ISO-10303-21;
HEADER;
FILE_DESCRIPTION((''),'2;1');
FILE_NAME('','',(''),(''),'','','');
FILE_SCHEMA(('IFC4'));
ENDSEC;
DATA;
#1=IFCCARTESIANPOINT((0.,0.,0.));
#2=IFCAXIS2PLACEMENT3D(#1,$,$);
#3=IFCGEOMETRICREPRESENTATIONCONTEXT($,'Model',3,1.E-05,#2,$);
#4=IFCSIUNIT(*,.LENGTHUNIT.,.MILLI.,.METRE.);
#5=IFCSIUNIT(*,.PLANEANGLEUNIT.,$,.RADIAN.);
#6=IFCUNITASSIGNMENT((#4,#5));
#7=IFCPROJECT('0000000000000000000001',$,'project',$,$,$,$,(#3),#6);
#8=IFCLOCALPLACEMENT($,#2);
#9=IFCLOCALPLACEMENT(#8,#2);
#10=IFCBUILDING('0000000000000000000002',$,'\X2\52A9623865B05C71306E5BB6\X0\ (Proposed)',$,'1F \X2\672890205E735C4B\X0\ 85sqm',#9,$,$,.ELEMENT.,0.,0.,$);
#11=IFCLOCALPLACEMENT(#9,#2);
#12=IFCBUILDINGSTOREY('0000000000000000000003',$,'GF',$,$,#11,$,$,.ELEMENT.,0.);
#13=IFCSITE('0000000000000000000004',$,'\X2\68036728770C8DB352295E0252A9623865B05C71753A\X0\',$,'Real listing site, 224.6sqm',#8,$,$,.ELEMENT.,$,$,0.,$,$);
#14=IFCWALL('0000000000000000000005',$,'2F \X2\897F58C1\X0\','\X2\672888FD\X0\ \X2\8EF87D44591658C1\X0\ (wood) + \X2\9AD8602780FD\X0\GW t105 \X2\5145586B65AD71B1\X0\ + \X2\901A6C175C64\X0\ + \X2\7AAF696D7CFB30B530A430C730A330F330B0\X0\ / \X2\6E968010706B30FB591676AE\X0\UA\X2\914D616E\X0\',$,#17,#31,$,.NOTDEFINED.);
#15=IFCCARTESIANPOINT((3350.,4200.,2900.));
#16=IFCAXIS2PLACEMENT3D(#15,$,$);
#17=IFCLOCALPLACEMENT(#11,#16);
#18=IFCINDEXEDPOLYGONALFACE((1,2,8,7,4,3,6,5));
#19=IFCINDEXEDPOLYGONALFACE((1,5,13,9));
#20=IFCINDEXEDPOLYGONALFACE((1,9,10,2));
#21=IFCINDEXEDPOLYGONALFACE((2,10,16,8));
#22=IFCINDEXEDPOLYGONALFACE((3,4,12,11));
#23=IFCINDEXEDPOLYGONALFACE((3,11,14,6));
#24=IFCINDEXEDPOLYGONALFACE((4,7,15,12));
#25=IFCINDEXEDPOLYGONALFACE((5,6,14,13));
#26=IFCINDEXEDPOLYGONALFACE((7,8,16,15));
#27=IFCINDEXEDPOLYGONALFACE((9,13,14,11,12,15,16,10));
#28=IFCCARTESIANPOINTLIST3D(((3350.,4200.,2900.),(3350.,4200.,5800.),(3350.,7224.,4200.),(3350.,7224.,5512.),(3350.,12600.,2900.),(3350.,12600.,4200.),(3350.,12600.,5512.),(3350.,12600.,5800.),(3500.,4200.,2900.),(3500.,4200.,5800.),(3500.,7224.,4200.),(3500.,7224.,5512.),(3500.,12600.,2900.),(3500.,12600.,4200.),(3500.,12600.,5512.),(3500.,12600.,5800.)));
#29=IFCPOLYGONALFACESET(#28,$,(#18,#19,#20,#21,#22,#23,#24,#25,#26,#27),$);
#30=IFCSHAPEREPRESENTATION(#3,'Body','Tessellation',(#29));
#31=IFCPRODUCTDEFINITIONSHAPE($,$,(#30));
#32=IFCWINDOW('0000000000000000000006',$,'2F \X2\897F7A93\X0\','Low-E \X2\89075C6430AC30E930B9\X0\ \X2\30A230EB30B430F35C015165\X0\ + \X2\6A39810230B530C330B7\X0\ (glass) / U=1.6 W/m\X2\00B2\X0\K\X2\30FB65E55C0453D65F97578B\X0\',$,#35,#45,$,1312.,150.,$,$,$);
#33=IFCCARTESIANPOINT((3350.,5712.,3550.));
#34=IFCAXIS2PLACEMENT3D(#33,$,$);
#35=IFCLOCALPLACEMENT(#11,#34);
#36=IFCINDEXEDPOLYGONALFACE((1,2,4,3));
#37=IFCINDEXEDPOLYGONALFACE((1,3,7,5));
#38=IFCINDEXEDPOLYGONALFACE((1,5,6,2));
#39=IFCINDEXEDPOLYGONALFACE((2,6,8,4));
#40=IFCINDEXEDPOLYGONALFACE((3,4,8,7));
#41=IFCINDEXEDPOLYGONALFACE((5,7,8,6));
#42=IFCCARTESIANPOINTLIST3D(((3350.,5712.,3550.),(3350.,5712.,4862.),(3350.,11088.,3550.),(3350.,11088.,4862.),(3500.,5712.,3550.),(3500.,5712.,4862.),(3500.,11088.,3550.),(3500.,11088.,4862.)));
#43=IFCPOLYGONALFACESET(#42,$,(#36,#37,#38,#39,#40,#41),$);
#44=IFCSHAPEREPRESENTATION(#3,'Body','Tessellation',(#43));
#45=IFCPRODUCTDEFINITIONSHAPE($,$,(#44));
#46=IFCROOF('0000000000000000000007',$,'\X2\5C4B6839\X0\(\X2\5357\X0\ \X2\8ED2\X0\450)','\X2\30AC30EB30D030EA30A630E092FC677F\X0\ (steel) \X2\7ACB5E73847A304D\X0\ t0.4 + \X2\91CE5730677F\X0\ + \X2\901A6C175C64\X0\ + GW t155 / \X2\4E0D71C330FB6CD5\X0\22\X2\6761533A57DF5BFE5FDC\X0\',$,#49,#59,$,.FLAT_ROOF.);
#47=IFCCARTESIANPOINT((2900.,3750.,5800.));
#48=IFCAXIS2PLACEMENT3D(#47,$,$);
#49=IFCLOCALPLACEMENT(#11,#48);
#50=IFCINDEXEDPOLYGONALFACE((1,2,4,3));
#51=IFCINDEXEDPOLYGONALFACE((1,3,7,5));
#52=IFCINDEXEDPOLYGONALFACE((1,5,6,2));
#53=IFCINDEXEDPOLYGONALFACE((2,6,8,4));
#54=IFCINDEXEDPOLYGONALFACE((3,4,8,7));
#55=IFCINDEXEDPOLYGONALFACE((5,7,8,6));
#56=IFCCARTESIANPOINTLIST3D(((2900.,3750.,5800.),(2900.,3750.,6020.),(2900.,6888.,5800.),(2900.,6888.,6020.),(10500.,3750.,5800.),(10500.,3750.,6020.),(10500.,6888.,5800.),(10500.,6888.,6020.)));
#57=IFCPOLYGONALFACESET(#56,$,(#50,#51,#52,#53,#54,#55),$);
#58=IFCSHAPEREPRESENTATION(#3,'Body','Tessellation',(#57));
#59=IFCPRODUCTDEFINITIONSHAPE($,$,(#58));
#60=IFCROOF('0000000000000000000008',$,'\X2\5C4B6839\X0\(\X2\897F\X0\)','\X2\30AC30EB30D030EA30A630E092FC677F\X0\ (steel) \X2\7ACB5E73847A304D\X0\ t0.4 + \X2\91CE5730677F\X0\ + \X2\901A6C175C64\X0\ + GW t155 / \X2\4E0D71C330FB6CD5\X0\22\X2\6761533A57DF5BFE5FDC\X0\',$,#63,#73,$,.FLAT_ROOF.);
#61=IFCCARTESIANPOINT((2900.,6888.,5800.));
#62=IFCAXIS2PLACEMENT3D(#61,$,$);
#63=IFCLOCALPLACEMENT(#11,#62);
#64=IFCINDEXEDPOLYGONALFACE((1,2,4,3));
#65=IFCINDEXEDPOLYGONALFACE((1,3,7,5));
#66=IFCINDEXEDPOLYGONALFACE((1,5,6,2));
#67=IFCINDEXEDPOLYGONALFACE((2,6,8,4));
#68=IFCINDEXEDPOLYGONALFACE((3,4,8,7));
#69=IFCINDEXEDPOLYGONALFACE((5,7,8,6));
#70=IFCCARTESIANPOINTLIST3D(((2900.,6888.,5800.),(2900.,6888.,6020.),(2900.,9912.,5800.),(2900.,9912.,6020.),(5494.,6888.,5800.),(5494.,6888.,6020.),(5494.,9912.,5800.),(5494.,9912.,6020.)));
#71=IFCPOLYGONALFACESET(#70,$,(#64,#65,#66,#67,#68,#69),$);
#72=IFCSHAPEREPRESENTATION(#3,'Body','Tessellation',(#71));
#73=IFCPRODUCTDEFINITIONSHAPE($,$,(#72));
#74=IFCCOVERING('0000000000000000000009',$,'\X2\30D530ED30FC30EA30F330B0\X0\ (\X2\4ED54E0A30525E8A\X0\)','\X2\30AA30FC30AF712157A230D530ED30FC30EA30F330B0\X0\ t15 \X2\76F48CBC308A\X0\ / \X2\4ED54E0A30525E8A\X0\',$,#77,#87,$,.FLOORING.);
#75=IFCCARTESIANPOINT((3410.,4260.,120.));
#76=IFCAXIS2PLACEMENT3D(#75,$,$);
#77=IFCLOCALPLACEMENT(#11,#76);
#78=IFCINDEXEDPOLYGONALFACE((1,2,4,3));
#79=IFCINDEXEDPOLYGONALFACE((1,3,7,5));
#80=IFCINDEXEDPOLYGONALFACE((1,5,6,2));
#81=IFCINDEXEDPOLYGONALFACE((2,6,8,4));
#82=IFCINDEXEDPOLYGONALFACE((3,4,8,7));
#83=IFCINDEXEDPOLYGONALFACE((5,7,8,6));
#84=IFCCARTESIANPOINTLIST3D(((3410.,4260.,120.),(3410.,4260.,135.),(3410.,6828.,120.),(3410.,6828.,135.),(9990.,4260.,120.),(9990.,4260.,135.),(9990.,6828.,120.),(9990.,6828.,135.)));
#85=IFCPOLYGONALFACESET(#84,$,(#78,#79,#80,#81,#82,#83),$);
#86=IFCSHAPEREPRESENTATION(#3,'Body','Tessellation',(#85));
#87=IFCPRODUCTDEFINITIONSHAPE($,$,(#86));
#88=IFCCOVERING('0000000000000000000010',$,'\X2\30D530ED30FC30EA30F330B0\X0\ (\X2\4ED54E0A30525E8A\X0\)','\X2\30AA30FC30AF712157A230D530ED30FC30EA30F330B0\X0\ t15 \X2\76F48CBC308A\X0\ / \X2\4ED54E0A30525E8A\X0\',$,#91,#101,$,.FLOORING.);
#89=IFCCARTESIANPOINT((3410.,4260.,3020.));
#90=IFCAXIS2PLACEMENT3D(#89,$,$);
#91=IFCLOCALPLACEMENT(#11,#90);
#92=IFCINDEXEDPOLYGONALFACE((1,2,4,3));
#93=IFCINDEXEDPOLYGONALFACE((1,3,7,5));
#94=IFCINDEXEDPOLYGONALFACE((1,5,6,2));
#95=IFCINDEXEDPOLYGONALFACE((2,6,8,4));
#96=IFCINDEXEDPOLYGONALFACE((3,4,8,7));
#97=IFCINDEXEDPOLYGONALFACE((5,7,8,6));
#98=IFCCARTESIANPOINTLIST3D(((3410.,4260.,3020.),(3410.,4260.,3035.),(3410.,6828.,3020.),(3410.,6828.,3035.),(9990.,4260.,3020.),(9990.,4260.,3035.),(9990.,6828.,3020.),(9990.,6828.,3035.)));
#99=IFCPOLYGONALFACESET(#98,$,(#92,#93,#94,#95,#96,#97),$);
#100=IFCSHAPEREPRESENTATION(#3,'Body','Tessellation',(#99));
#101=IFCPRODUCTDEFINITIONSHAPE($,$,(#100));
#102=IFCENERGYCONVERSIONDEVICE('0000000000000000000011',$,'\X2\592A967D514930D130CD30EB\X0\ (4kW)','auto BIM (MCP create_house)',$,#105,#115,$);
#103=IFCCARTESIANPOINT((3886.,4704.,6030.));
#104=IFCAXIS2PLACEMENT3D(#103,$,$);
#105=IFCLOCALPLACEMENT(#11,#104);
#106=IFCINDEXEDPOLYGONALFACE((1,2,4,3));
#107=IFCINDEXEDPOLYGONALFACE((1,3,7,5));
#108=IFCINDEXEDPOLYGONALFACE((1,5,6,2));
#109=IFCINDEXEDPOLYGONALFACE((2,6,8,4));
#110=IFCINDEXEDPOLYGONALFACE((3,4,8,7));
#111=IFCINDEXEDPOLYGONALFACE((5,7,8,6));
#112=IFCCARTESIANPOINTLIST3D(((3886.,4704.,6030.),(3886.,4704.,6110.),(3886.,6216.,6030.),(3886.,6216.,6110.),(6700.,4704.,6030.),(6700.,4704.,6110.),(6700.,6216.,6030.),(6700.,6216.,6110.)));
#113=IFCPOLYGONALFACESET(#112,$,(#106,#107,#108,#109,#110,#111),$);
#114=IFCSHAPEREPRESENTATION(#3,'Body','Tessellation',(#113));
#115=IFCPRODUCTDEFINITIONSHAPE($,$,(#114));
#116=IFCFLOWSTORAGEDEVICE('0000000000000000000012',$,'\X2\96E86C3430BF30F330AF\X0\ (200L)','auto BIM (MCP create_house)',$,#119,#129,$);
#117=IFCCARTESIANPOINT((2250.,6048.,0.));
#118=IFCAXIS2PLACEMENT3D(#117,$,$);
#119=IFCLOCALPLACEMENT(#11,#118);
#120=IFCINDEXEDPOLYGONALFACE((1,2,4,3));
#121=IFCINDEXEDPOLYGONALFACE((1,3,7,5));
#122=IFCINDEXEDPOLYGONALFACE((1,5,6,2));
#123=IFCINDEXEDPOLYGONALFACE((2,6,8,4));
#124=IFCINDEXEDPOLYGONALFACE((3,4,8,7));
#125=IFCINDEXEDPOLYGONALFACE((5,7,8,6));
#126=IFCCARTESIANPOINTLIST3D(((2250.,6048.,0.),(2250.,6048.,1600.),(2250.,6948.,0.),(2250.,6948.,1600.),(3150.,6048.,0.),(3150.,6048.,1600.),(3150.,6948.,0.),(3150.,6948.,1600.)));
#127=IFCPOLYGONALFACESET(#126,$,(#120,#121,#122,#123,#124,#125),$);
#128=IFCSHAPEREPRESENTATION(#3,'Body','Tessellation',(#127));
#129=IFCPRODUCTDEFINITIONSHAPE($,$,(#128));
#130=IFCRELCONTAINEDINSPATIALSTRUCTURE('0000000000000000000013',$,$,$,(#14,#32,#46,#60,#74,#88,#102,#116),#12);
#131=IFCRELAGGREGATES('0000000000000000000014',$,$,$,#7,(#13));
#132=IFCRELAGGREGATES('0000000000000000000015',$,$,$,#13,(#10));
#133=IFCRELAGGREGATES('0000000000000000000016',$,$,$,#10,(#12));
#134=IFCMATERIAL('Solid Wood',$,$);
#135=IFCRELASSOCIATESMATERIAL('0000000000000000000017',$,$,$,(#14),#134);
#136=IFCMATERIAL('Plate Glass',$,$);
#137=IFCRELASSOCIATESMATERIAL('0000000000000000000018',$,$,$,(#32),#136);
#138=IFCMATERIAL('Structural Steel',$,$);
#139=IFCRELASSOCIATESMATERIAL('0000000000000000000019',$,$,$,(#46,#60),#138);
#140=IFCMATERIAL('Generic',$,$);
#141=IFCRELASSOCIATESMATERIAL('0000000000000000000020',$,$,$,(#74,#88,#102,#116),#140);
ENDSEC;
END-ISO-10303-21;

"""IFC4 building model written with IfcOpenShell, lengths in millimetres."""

from ifc_helpers import new_model, si_unit, frame, frame_2d, origin, place, context, project, spatial, rectangle, extrude, material, element, fill, save


model = new_model("IFC4")

# Units and contexts
model_context = context("Model", 3, precision=1e-05, world=origin())
ifc_project = project(units=[si_unit("LENGTHUNIT", "METRE", prefix="MILLI"), si_unit("PLANEANGLEUNIT", "RADIAN")], contexts=[model_context])

# Site, building, storey
site_placement = place(None, origin())
site = spatial("IfcSite", under=ifc_project, at=site_placement, Name="栃木県足利市助戸新山町", ObjectType="Real listing site, 224.6sqm", CompositionType="ELEMENT", RefElevation=0.0)
building_placement = place(site_placement, origin())
building = spatial("IfcBuilding", under=site, at=building_placement, Name="助戸新山の家 (Proposed)", ObjectType="1F 木造平屋 85sqm", CompositionType="ELEMENT", ElevationOfRefHeight=0.0, ElevationOfTerrain=0.0)
storey_placement = place(building_placement, origin())
storey = spatial("IfcBuildingStorey", under=building, at=storey_placement, Name="GF", CompositionType="ELEMENT", Elevation=0.0)

# Shared definitions
ifc_material_1 = material(Name="Solid Wood")
ifc_material_2 = material(Name="Generic")

# Shared definitions
ifc_material_3 = material(Name="Plate Glass")

# Wall, opening, window
wall_1_placement = place(storey_placement, frame((3350.0, 4200.0, 2900.0)))
wall_1 = element("IfcWall", 1, at=wall_1_placement, inside=storey, material=ifc_material_1, Name="2F 西壁", Description="木製 軸組外壁 (wood) + 高性能GW t105 充填断熱 + 通気層 + 窯業系サイディング / 準耐火・外皮UA配慮", PredefinedType="NOTDEFINED", context=model_context, shape_type="SweptSolid", body=[
    extrude(rectangle(XDim=150.0, YDim=8400.0, at=frame_2d((75.0, 4200.0))), frame((3350.0, 4200.0, 2900.0)), (0.0, 0.0, 1.0), 2900.0),
])
opening_1_placement = place(storey_placement, frame((3350.0, 5712.0, 3550.0)))
opening_1 = element("IfcOpeningElement", 2, at=opening_1_placement, cuts=wall_1, PredefinedType="NOTDEFINED", context=model_context, shape_type="SweptSolid", body=[
    extrude(rectangle(XDim=150.0, YDim=5376.0, at=frame_2d((75.0, 2688.0))), frame((3350.0, 5712.0, 3550.0)), (0.0, 0.0, 1.0), 1312.0),
])
window_1_placement = place(storey_placement, frame((3350.0, 5712.0, 3550.0)))
window_1 = element("IfcWindow", 3, at=window_1_placement, inside=storey, material=ifc_material_3, Name="2F 西窓", Description="Low-E 複層ガラス アルゴン封入 + 樹脂サッシ (glass) / U=1.6 W/m²K・日射取得型", OverallHeight=1312.0, OverallWidth=150.0, context=model_context, shape_type="SweptSolid", body=[
    extrude(rectangle(XDim=150.0, YDim=5376.0, at=frame_2d((75.0, 2688.0))), frame((3350.0, 5712.0, 3550.0)), (0.0, 0.0, 1.0), 1312.0),
])
fill(opening_1, window_1)

# Roofs
ifc_material_4 = material(Name="Structural Steel")
roof_1_placement = place(storey_placement, frame((2900.0, 3750.0, 5800.0)))
element("IfcRoof", 4, at=roof_1_placement, inside=storey, material=ifc_material_4, Name="屋根(南 軒450)", Description="ガルバリウム鋼板 (steel) 立平葺き t0.4 + 野地板 + 通気層 + GW t155 / 不燃・法22条区域対応", PredefinedType="FLAT_ROOF", context=model_context, shape_type="SweptSolid", body=[
    extrude(rectangle(XDim=7600.0, YDim=3138.0, at=frame_2d((3800.0, 1569.0))), frame((2900.0, 3750.0, 5800.0)), (0.0, 0.0, 1.0), 220.0),
])
roof_2_placement = place(storey_placement, frame((2900.0, 6888.0, 5800.0)))
element("IfcRoof", 5, at=roof_2_placement, inside=storey, material=ifc_material_4, Name="屋根(西)", Description="ガルバリウム鋼板 (steel) 立平葺き t0.4 + 野地板 + 通気層 + GW t155 / 不燃・法22条区域対応", PredefinedType="FLAT_ROOF", context=model_context, shape_type="SweptSolid", body=[
    extrude(rectangle(XDim=2594.0, YDim=3024.0, at=frame_2d((1297.0, 1512.0))), frame((2900.0, 6888.0, 5800.0)), (0.0, 0.0, 1.0), 220.0),
])

# Coverings
covering_1_placement = place(storey_placement, frame((3410.0, 4260.0, 120.0)))
element("IfcCovering", 6, at=covering_1_placement, inside=storey, material=ifc_material_2, Name="フローリング (仕上げ床)", Description="オーク無垢フローリング t15 直貼り / 仕上げ床", PredefinedType="FLOORING", context=model_context, shape_type="SweptSolid", body=[
    extrude(rectangle(XDim=6580.0, YDim=2568.0, at=frame_2d((3290.0, 1284.0))), frame((3410.0, 4260.0, 120.0)), (0.0, 0.0, 1.0), 15.0),
])
covering_2_placement = place(storey_placement, frame((3410.0, 4260.0, 3020.0)))
element("IfcCovering", 7, at=covering_2_placement, inside=storey, material=ifc_material_2, Name="フローリング (仕上げ床)", Description="オーク無垢フローリング t15 直貼り / 仕上げ床", PredefinedType="FLOORING", context=model_context, shape_type="SweptSolid", body=[
    extrude(rectangle(XDim=6580.0, YDim=2568.0, at=frame_2d((3290.0, 1284.0))), frame((3410.0, 4260.0, 3020.0)), (0.0, 0.0, 1.0), 15.0),
])

# Energy conversion device
energy_conversion_device_placement = place(storey_placement, frame((3886.0, 4704.0, 6030.0)))
element("IfcEnergyConversionDevice", 8, at=energy_conversion_device_placement, inside=storey, material=ifc_material_2, Name="太陽光パネル (4kW)", Description="auto BIM (MCP create_house)", context=model_context, shape_type="SweptSolid", body=[
    extrude(rectangle(XDim=2814.0, YDim=1512.0, at=frame_2d((1407.0, 756.0))), frame((3886.0, 4704.0, 6030.0)), (0.0, 0.0, 1.0), 80.0),
])

# Flow storage device
flow_storage_device_placement = place(storey_placement, frame((2250.0, 6048.0, 0.0)))
element("IfcFlowStorageDevice", 9, at=flow_storage_device_placement, inside=storey, material=ifc_material_2, Name="雨水タンク (200L)", Description="auto BIM (MCP create_house)", context=model_context, shape_type="SweptSolid", body=[
    extrude(rectangle(XDim=900.0, YDim=900.0, at=frame_2d((450.0, 450.0))), frame((2250.0, 6048.0, 0.0)), (0.0, 0.0, 1.0), 1600.0),
])

save(model, "model.ifc")
